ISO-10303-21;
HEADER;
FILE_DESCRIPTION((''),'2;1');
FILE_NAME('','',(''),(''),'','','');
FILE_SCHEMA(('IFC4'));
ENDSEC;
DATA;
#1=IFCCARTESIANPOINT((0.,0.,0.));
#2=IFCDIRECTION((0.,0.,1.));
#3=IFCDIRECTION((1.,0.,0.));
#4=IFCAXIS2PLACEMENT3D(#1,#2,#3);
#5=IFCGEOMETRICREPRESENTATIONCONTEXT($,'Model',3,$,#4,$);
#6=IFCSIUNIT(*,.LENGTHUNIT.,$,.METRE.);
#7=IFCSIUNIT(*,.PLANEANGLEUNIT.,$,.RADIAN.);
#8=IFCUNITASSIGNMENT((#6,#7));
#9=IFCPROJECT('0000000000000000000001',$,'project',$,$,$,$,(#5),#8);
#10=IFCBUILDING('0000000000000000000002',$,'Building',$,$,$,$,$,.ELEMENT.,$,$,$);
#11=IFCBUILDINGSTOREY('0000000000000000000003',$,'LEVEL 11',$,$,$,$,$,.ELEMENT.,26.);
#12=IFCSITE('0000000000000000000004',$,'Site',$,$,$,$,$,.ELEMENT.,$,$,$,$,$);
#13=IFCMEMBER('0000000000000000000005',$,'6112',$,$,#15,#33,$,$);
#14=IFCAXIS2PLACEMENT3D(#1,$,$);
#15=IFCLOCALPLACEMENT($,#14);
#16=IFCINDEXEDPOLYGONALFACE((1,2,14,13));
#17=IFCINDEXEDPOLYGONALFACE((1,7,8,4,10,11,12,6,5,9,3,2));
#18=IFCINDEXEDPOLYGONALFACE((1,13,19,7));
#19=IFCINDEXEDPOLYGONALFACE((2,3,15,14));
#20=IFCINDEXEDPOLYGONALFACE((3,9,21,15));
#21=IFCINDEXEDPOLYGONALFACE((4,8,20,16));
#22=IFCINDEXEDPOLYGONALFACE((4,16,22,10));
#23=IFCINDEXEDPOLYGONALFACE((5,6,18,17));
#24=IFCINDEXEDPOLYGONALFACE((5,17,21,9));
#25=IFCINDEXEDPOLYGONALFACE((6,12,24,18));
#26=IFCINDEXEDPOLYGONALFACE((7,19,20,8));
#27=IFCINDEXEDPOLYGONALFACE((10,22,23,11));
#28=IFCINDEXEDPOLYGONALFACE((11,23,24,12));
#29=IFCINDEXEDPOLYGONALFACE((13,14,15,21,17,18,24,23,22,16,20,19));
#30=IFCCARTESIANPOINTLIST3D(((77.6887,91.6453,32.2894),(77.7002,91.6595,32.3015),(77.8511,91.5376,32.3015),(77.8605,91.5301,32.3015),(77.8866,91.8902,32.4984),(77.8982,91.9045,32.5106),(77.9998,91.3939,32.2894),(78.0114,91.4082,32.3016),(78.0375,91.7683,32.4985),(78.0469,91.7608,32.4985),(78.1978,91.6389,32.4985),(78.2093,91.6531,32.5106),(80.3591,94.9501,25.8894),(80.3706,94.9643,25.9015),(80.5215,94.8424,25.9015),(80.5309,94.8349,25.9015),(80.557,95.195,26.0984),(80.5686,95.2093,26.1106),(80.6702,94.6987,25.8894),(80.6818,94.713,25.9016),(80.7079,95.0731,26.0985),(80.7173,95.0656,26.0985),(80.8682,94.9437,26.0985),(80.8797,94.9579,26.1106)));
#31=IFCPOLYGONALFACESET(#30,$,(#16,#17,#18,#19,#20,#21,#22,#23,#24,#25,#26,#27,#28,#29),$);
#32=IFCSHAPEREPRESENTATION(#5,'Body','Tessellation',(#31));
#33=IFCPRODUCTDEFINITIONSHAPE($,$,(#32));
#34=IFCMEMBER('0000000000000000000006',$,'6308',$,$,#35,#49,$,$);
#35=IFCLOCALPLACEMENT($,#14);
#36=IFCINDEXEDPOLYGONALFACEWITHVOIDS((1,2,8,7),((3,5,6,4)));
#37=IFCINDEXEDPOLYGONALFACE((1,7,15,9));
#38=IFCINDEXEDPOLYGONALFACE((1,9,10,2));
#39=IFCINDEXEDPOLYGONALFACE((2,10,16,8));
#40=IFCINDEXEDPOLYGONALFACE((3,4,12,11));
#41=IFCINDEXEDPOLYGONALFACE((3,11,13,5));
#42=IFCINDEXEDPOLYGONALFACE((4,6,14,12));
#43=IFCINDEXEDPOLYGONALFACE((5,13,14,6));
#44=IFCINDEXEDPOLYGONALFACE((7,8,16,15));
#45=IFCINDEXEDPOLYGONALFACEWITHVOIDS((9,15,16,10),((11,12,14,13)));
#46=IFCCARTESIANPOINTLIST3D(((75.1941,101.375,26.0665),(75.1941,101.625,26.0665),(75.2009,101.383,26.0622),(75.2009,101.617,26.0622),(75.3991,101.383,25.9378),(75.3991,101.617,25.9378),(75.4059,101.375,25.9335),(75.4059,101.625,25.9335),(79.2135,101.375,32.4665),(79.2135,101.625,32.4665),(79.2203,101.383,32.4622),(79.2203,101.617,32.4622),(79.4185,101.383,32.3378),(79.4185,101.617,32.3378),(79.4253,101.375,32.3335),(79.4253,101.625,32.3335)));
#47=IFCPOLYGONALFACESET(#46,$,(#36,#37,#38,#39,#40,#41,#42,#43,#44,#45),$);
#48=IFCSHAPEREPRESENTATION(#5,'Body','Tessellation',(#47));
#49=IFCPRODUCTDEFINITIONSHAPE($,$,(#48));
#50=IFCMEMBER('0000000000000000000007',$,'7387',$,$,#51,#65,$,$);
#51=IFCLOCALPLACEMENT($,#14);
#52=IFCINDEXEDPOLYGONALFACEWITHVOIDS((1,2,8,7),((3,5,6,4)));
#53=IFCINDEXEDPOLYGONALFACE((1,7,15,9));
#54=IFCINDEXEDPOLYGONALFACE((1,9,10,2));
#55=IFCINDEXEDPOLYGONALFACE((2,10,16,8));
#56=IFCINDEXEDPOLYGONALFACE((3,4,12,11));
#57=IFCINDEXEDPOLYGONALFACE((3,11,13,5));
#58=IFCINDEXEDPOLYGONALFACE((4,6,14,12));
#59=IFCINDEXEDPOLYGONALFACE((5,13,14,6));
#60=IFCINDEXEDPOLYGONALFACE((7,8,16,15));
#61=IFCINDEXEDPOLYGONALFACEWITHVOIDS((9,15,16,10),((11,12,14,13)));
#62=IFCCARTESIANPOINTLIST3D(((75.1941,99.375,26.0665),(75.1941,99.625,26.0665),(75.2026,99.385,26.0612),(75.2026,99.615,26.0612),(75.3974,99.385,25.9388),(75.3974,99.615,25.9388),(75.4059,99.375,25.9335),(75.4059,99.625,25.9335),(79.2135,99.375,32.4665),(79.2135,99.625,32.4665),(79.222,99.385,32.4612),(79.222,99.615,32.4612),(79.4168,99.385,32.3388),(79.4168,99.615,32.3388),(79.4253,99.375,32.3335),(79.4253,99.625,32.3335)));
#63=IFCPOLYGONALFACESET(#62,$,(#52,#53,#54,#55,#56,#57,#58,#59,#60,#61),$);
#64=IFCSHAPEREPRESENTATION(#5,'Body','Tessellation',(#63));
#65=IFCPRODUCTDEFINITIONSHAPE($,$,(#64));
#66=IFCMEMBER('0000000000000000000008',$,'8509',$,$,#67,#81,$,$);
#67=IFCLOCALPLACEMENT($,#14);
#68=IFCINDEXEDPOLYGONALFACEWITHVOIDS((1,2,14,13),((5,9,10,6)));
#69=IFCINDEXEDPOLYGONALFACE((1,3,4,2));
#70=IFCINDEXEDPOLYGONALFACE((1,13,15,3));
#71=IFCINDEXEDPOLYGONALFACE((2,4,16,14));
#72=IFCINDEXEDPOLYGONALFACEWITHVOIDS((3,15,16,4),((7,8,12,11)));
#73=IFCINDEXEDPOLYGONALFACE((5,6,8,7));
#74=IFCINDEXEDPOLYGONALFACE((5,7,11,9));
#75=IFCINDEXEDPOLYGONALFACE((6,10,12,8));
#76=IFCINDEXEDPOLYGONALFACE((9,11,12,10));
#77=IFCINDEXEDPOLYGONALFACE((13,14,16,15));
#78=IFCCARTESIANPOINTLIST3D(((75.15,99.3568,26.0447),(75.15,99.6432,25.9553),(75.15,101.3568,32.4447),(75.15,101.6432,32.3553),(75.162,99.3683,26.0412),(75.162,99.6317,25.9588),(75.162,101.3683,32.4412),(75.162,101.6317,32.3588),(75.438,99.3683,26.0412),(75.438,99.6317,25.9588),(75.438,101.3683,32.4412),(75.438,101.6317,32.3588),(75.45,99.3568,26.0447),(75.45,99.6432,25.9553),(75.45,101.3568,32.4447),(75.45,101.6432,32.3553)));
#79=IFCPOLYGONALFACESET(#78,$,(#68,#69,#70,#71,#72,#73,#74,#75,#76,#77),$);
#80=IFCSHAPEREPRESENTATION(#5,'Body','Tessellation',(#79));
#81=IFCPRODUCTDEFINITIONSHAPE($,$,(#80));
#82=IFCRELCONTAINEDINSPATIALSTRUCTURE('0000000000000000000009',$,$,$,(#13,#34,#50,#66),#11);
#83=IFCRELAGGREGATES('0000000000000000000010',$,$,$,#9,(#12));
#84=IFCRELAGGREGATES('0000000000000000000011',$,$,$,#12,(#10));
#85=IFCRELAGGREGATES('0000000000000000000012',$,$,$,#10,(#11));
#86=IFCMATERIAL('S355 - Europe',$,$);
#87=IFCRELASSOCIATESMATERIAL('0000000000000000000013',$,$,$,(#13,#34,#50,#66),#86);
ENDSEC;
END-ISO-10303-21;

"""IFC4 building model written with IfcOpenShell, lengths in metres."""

from ifc_helpers import new_model, si_unit, frame, origin_with_axes, origin_2d_with_axis, place, context, project, spatial, hollow_rectangle, i_section, extrude, material, material_profile, profile_set, profile_usage, element, save


model = new_model("IFC4")

# Units and contexts
model_context = context("Model", 3, world=origin_with_axes())
ifc_project = project(units=[si_unit("LENGTHUNIT", "METRE"), si_unit("PLANEANGLEUNIT", "RADIAN")], contexts=[model_context])

# Site, building, storey
site = spatial("IfcSite", under=ifc_project, Name="Site", CompositionType="ELEMENT")
building = spatial("IfcBuilding", under=site, Name="Building", CompositionType="ELEMENT")
storey = spatial("IfcBuildingStorey", under=building, Name="LEVEL 11", CompositionType="ELEMENT", Elevation=26.0)

# Shared definitions
ifc_material = material(Name="S355 - Europe")

# Members
ifc_material_profile_1 = material_profile(ifc_material, i_section(OverallWidth=0.4, OverallDepth=0.4, WebThickness=0.012, FlangeThickness=0.022, at=origin_2d_with_axis()))
ifc_profile_set_1 = profile_set([ifc_material_profile_1])
ifc_profile_usage_1 = profile_usage(ifc_profile_set_1, cardinal=10)
member_1_placement = place(None, frame((77.949, 91.6492, 32.4), z_axis=(0.347619, 0.430202, -0.833119), x_axis=(-0.777826, 0.62848, 0.0)))
element("IfcMember", 1, at=member_1_placement, inside=storey, material=ifc_profile_usage_1, Name="6112", context=model_context, shape_type="SweptSolid", body=[
    extrude(i_section(OverallWidth=0.4, OverallDepth=0.4, WebThickness=0.012, FlangeThickness=0.022, at=origin_2d_with_axis()), origin_with_axes(), (0.0, 0.0, 1.0), 7.682),
])
ifc_material_profile_2 = material_profile(ifc_material, hollow_rectangle(XDim=0.25, YDim=0.25, WallThickness=0.008, at=origin_2d_with_axis()))
ifc_profile_set_2 = profile_set([ifc_material_profile_2])
ifc_profile_usage_2 = profile_usage(ifc_profile_set_2, cardinal=10)
member_2_placement = place(None, frame((79.3194, 101.5, 32.4), z_axis=(-0.531844, 0.0, -0.846843), x_axis=(0.0, -1.0, 0.0)))
element("IfcMember", 2, at=member_2_placement, inside=storey, material=ifc_profile_usage_2, Name="6308", context=model_context, shape_type="SweptSolid", body=[
    extrude(hollow_rectangle(XDim=0.25, YDim=0.25, WallThickness=0.008, at=origin_2d_with_axis()), origin_with_axes(), (0.0, 0.0, 1.0), 7.5575),
])
ifc_material_profile_3 = material_profile(ifc_material, hollow_rectangle(XDim=0.25, YDim=0.25, WallThickness=0.01, at=origin_2d_with_axis()))
ifc_profile_set_3 = profile_set([ifc_material_profile_3])
ifc_profile_usage_3 = profile_usage(ifc_profile_set_3, cardinal=10)
member_3_placement = place(None, frame((79.3194, 99.5, 32.4), z_axis=(-0.531844, 0.0, -0.846843), x_axis=(0.0, -1.0, 0.0)))
element("IfcMember", 3, at=member_3_placement, inside=storey, material=ifc_profile_usage_3, Name="7387", context=model_context, shape_type="SweptSolid", body=[
    extrude(hollow_rectangle(XDim=0.25, YDim=0.25, WallThickness=0.01, at=origin_2d_with_axis()), origin_with_axes(), (0.0, 0.0, 1.0), 7.5575),
])
ifc_material_profile_4 = material_profile(ifc_material, hollow_rectangle(XDim=0.3, YDim=0.3, WallThickness=0.012, at=origin_2d_with_axis()))
ifc_profile_set_4 = profile_set([ifc_material_profile_4])
ifc_profile_usage_4 = profile_usage(ifc_profile_set_4, cardinal=10)
member_4_placement = place(None, frame((75.3, 101.5, 32.4), z_axis=(0.0, -0.298275, -0.95448), x_axis=(1.0, 0.0, 0.0)))
element("IfcMember", 4, at=member_4_placement, inside=storey, material=ifc_profile_usage_4, Name="8509", context=model_context, shape_type="SweptSolid", body=[
    extrude(hollow_rectangle(XDim=0.3, YDim=0.3, WallThickness=0.012, at=origin_2d_with_axis()), origin_with_axes(), (0.0, 0.0, 1.0), 6.7052),
])

save(model, "model.ifc")
